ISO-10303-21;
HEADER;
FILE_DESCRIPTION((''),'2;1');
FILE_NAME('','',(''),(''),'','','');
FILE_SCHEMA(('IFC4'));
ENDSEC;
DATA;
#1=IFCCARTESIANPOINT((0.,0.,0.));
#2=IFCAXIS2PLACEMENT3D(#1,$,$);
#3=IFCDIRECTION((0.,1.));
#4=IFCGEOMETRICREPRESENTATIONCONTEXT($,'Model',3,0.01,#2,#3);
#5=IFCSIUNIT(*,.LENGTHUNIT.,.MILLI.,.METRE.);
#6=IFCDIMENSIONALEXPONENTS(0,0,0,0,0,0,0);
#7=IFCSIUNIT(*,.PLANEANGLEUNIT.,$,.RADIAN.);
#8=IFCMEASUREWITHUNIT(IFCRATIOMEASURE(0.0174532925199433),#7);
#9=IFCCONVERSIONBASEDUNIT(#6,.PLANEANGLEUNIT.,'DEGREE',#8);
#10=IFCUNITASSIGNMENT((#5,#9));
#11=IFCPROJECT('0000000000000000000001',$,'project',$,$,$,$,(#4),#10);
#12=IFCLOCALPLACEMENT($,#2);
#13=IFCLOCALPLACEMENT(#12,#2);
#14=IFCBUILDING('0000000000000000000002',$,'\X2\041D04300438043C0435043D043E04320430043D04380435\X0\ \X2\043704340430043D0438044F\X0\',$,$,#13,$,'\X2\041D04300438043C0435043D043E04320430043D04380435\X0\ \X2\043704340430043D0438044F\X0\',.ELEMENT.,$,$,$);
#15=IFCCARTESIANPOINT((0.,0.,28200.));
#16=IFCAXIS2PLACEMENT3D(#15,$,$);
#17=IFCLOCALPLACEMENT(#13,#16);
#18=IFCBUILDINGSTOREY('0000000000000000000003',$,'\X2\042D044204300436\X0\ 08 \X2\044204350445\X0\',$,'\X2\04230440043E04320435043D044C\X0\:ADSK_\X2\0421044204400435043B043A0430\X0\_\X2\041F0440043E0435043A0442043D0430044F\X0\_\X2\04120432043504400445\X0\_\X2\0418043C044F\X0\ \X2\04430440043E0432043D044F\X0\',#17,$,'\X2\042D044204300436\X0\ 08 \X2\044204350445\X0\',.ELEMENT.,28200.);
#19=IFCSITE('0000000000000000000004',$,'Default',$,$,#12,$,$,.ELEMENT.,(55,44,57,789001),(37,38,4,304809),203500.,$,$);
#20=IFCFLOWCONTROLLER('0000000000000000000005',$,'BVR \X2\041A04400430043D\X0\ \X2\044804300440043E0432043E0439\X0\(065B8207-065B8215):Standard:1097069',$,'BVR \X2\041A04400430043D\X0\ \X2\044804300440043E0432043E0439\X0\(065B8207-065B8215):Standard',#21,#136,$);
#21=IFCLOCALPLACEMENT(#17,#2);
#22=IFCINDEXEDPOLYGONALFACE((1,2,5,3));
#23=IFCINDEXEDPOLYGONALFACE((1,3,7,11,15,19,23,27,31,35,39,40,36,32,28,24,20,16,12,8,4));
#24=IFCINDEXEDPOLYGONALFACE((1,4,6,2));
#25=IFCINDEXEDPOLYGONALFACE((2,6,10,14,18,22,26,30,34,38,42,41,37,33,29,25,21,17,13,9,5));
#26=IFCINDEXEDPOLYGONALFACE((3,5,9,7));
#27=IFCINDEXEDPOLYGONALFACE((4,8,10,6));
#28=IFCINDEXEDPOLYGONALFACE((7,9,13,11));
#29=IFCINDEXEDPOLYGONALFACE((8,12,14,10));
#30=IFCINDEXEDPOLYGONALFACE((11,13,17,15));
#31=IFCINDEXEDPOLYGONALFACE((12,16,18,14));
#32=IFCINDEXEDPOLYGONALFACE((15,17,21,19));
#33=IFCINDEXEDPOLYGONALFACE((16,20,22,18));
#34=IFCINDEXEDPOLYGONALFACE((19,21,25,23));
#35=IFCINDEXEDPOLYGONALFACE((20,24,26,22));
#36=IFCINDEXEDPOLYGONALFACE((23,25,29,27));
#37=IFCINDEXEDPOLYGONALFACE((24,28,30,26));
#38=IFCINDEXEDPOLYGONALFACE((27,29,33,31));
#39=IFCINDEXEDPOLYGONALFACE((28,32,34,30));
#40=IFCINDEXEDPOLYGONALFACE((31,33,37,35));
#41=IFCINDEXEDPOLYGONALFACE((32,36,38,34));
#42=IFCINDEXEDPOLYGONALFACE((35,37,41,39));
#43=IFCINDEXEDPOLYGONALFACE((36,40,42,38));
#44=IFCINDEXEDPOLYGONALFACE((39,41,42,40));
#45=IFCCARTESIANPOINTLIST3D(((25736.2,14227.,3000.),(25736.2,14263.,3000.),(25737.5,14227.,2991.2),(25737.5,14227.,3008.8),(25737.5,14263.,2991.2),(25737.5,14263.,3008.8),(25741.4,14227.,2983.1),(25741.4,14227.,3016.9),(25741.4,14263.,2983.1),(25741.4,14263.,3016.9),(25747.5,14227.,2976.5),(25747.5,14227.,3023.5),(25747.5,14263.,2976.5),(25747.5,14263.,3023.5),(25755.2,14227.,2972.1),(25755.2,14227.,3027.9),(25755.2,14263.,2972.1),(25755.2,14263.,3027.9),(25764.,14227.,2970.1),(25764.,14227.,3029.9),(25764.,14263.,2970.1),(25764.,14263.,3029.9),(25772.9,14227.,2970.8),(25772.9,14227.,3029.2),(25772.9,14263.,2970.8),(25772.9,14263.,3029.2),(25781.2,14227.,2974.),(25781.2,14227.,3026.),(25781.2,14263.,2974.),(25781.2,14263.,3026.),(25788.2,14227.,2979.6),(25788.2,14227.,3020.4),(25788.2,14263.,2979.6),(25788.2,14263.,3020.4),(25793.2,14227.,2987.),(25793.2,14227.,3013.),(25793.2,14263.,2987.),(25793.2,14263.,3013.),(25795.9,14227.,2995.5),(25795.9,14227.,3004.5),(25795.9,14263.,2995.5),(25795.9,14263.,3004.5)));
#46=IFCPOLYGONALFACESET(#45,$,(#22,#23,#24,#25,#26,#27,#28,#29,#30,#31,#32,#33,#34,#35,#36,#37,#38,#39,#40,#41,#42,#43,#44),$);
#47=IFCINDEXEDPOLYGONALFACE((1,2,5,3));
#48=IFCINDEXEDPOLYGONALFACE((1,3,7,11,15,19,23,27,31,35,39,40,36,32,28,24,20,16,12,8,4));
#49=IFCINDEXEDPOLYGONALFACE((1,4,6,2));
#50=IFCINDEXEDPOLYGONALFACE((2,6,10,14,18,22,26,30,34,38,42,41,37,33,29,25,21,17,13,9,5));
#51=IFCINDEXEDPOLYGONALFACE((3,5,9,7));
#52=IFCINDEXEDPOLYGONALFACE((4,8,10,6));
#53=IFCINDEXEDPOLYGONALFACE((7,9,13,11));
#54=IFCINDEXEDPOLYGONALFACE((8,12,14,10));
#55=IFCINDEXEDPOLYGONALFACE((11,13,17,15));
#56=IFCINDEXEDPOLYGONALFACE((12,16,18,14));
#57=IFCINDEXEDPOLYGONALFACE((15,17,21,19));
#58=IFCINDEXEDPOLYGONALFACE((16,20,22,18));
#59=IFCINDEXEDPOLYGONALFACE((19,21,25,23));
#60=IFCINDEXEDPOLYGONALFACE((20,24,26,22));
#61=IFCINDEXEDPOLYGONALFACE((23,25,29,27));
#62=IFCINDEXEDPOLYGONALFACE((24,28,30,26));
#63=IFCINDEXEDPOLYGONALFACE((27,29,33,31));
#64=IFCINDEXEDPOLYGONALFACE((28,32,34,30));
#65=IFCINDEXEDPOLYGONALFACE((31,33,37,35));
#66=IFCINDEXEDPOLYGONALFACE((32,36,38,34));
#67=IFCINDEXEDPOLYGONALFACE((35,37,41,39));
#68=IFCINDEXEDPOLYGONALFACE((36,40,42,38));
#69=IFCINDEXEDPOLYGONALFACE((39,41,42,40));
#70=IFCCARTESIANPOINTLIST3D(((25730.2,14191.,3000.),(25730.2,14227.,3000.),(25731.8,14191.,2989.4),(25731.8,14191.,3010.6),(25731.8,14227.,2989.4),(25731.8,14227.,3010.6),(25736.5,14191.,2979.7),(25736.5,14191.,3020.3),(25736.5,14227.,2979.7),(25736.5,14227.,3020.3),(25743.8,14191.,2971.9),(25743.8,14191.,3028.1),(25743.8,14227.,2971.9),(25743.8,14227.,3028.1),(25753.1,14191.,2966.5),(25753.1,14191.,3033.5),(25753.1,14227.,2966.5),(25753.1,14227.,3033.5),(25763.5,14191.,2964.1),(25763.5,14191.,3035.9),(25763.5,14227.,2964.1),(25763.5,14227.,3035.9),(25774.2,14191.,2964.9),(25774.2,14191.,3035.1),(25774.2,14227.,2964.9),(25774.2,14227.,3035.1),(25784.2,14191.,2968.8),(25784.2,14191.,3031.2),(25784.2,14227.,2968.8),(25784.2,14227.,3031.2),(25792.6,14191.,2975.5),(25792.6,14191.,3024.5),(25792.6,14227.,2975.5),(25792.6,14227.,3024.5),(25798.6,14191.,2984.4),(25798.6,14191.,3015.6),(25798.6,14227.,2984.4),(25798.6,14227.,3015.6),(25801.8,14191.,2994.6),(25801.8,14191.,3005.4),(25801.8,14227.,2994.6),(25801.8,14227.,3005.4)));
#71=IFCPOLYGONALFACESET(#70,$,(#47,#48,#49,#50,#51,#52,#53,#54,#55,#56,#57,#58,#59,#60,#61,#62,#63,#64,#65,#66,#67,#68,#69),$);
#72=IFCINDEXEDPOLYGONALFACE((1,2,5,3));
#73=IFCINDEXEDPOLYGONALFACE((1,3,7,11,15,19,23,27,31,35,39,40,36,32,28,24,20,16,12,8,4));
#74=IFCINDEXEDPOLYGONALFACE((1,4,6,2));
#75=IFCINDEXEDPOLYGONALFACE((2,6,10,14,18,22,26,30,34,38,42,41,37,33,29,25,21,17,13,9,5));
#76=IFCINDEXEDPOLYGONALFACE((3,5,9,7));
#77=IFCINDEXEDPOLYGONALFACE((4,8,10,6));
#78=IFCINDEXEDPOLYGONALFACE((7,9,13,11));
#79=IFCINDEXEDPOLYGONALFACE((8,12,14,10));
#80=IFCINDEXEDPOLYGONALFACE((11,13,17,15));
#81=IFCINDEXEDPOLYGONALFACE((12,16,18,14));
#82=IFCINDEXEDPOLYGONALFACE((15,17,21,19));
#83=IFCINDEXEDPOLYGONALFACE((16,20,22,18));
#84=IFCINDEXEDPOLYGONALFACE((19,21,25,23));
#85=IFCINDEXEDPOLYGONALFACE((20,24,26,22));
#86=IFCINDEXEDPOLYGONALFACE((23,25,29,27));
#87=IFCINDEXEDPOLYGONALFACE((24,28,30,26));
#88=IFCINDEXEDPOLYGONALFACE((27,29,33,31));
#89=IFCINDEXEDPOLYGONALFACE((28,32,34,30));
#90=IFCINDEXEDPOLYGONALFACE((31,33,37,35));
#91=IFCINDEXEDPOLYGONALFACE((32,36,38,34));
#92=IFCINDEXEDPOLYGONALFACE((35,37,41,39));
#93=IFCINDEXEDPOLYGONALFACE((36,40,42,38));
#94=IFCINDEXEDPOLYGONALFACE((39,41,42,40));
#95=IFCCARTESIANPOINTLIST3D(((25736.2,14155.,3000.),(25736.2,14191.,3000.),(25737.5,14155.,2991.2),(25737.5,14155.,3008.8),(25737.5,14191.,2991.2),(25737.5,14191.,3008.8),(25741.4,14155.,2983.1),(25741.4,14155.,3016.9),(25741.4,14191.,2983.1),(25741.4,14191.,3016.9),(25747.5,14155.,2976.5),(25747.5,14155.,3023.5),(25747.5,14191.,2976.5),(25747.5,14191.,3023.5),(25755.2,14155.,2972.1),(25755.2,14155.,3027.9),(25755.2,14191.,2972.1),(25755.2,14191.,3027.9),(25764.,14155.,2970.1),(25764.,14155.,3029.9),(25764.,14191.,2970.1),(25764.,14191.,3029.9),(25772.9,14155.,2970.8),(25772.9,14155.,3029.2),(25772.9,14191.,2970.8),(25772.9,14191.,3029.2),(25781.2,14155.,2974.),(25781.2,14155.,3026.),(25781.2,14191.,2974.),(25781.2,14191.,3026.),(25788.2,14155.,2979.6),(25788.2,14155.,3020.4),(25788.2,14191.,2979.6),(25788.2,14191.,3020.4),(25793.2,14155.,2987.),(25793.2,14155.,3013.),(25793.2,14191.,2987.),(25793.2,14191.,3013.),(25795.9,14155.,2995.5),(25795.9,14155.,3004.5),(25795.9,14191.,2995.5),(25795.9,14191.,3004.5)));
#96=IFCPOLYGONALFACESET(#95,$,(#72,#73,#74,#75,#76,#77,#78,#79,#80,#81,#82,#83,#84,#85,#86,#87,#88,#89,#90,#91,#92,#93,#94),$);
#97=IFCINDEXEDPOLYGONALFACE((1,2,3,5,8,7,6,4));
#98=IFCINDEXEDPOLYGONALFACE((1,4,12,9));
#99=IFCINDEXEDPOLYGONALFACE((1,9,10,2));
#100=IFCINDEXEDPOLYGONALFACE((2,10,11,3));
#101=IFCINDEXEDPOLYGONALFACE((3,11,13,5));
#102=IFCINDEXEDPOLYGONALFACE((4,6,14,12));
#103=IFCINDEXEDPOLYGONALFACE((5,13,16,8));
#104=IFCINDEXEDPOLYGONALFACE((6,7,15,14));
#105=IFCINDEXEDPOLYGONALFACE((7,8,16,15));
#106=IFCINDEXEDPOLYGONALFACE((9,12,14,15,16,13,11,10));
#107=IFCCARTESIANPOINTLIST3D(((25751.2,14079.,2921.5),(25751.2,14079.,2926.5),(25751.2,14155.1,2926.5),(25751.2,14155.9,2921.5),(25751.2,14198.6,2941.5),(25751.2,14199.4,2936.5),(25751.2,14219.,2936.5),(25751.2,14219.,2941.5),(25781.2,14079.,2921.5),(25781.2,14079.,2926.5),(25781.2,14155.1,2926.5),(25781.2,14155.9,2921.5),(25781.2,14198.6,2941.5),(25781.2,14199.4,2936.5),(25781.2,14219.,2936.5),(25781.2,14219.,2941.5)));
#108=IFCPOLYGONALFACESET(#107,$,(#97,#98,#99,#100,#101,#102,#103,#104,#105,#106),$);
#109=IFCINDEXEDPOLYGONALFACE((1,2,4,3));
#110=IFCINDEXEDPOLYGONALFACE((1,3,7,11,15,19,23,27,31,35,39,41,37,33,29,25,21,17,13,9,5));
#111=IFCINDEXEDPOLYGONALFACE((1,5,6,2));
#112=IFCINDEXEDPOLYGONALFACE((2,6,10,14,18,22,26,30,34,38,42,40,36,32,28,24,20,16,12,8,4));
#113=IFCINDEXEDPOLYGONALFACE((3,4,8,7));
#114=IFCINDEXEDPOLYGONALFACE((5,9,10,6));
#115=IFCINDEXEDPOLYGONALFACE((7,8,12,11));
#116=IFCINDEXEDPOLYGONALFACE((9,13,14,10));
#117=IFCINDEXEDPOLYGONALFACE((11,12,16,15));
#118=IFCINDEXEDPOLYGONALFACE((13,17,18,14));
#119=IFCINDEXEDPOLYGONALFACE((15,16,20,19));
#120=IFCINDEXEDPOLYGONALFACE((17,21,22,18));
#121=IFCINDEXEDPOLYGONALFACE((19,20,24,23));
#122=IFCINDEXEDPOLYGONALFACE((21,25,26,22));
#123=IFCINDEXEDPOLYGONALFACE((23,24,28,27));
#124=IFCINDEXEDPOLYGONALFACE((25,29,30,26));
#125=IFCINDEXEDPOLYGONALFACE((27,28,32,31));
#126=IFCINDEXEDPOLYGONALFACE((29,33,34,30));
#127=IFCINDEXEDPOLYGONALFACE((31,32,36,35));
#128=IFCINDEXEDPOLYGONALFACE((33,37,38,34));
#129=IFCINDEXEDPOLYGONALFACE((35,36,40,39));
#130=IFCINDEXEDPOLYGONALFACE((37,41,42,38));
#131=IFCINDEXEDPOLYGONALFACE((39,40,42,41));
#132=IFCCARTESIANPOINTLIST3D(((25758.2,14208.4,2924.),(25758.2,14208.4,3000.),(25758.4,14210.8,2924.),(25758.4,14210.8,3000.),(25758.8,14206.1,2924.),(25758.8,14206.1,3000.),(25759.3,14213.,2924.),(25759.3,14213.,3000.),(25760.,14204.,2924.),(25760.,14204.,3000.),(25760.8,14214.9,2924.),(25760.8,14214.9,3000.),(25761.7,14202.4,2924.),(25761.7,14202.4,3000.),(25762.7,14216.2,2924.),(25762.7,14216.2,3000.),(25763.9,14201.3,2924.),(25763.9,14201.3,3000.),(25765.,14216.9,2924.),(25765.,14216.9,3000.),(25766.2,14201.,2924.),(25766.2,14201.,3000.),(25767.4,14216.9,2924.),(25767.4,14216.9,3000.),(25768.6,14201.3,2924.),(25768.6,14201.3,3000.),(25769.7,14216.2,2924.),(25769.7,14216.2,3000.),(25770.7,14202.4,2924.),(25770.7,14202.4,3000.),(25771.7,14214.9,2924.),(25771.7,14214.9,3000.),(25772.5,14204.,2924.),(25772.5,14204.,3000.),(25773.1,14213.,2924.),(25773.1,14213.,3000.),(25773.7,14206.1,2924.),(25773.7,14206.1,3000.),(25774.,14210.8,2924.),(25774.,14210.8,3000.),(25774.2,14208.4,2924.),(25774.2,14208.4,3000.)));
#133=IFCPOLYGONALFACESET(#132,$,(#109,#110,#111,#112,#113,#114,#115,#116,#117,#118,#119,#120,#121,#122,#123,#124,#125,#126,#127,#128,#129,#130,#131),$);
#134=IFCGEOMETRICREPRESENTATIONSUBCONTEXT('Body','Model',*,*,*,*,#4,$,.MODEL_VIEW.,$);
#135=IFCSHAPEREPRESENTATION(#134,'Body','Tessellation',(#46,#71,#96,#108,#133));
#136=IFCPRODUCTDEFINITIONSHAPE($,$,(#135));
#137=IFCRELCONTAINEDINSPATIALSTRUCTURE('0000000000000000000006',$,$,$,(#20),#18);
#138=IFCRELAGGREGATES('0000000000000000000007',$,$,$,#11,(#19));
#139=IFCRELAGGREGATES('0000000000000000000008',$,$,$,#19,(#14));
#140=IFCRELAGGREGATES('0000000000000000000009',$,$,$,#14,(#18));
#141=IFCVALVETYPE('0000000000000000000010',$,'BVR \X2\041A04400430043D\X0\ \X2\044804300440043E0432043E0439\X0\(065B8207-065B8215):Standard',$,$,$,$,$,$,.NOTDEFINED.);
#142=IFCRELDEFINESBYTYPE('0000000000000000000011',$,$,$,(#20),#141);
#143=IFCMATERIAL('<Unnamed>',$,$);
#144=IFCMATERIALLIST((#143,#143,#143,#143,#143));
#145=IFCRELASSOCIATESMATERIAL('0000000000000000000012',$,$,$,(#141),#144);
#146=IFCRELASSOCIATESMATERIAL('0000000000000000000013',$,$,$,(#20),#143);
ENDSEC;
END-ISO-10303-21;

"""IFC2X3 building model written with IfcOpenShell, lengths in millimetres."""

from ifc_helpers import new_model, entity, si_unit, converted_unit, direction, frame, origin, origin_2d_with_axis, place, context, subcontext, project, spatial, polyline, circle, outline, extrude, source, transform, mapped, material, material_list, type_object, type_shapes, element, save


model = new_model("IFC2X3")

# Units and contexts
model_context = context("Model", 3, precision=0.01, world=origin(), true_north=direction((0.0, 1.0)))
body_context = subcontext(model_context, "Body", "Model", "MODEL_VIEW")
ifc_project = project(units=[si_unit("LENGTHUNIT", "METRE", prefix="MILLI"), converted_unit("PLANEANGLEUNIT", "DEGREE", entity("IfcRatioMeasure", 0.0174532925199433), si_unit("PLANEANGLEUNIT", "RADIAN"), dimensions=[0, 0, 0, 0, 0, 0, 0])], contexts=[model_context])

# Site, building, storey
site_placement = place(None, origin())
site = spatial("IfcSite", under=ifc_project, at=site_placement, Name="Default", CompositionType="ELEMENT", RefLatitude=(55, 44, 57, 789001), RefLongitude=(37, 38, 4, 304809), RefElevation=203500.0)
building_placement = place(site_placement, origin())
building = spatial("IfcBuilding", under=site, at=building_placement, Name="Наименование здания", LongName="Наименование здания", CompositionType="ELEMENT")
storey_placement = place(building_placement, frame((0.0, 0.0, 28200.0)))
storey = spatial("IfcBuildingStorey", under=building, at=storey_placement, Name="Этаж 08 тех", ObjectType="Уровень:ADSK_Стрелка_Проектная_Вверх_Имя уровня", LongName="Этаж 08 тех", CompositionType="ELEMENT", Elevation=28200.0)

# Shared definitions
ifc_material = material(Name="<Unnamed>")
ifc_material_list_1 = material_list([ifc_material, ifc_material, ifc_material, ifc_material, ifc_material])

# Flow controller
valve_type_1 = type_object("IfcValveType", Name="BVR Кран шаровой(065B8207-065B8215):Standard", PredefinedType="NOTDEFINED", material=ifc_material_list_1)
shared_shape_1 = source(origin(), body_context, "Body", "SweptSolid", [
    extrude(circle(Radius=30.0, at=origin_2d_with_axis()), frame((-54.0, 0.0, 0.0), z_axis=(1.0, 0.0, 0.0), x_axis=(0.0, 1.0, 0.0)), (0.0, 0.0, 1.0), 36.0),
    extrude(circle(Radius=36.0, at=origin_2d_with_axis()), frame((-18.0, 0.0, 0.0), z_axis=(1.0, 0.0, 0.0), x_axis=(0.0, 1.0, 0.0)), (0.0, 0.0, 1.0), 36.0),
    extrude(circle(Radius=30.0, at=origin_2d_with_axis()), frame((18.0, 0.0, 0.0), z_axis=(1.0, 0.0, 0.0), x_axis=(0.0, 1.0, 0.0)), (0.0, 0.0, 1.0), 36.0),
    extrude(outline(polyline([(-55.9, -5.0), (-55.9, -10.0), (-35.5, -10.0), (8.0, 5.0), (84.1, 5.0), (84.1, 10.0), (7.2, 10.0), (-36.3, -5.0), (-55.9, -5.0)])), frame((45.9, -15.0, 68.5), z_axis=(0.0, -1.0, 0.0), x_axis=(1.0, 0.0, 0.0)), (0.0, 0.0, -1.0), 30.0),
    extrude(circle(Radius=8.0, at=origin_2d_with_axis()), origin(), (0.0, 0.0, 1.0), 76.0),
])
type_shapes(valve_type_1, [shared_shape_1])
flow_controller_1_placement = place(storey_placement, frame((25766.2, 14209.0, 3000.0), z_axis=(0.0, 0.0, -1.0), x_axis=(0.0, -1.0, 0.0)))
element("IfcFlowController", 1, at=flow_controller_1_placement, inside=storey, type_object=valve_type_1, material=ifc_material, Name="BVR Кран шаровой(065B8207-065B8215):Standard:1097069", ObjectType="BVR Кран шаровой(065B8207-065B8215):Standard", context=body_context, shape_type="MappedRepresentation", body=[
    mapped(shared_shape_1, transform((0.0, 0.0, 0.0), scale=1.0)),
])

save(model, "model.ifc")
